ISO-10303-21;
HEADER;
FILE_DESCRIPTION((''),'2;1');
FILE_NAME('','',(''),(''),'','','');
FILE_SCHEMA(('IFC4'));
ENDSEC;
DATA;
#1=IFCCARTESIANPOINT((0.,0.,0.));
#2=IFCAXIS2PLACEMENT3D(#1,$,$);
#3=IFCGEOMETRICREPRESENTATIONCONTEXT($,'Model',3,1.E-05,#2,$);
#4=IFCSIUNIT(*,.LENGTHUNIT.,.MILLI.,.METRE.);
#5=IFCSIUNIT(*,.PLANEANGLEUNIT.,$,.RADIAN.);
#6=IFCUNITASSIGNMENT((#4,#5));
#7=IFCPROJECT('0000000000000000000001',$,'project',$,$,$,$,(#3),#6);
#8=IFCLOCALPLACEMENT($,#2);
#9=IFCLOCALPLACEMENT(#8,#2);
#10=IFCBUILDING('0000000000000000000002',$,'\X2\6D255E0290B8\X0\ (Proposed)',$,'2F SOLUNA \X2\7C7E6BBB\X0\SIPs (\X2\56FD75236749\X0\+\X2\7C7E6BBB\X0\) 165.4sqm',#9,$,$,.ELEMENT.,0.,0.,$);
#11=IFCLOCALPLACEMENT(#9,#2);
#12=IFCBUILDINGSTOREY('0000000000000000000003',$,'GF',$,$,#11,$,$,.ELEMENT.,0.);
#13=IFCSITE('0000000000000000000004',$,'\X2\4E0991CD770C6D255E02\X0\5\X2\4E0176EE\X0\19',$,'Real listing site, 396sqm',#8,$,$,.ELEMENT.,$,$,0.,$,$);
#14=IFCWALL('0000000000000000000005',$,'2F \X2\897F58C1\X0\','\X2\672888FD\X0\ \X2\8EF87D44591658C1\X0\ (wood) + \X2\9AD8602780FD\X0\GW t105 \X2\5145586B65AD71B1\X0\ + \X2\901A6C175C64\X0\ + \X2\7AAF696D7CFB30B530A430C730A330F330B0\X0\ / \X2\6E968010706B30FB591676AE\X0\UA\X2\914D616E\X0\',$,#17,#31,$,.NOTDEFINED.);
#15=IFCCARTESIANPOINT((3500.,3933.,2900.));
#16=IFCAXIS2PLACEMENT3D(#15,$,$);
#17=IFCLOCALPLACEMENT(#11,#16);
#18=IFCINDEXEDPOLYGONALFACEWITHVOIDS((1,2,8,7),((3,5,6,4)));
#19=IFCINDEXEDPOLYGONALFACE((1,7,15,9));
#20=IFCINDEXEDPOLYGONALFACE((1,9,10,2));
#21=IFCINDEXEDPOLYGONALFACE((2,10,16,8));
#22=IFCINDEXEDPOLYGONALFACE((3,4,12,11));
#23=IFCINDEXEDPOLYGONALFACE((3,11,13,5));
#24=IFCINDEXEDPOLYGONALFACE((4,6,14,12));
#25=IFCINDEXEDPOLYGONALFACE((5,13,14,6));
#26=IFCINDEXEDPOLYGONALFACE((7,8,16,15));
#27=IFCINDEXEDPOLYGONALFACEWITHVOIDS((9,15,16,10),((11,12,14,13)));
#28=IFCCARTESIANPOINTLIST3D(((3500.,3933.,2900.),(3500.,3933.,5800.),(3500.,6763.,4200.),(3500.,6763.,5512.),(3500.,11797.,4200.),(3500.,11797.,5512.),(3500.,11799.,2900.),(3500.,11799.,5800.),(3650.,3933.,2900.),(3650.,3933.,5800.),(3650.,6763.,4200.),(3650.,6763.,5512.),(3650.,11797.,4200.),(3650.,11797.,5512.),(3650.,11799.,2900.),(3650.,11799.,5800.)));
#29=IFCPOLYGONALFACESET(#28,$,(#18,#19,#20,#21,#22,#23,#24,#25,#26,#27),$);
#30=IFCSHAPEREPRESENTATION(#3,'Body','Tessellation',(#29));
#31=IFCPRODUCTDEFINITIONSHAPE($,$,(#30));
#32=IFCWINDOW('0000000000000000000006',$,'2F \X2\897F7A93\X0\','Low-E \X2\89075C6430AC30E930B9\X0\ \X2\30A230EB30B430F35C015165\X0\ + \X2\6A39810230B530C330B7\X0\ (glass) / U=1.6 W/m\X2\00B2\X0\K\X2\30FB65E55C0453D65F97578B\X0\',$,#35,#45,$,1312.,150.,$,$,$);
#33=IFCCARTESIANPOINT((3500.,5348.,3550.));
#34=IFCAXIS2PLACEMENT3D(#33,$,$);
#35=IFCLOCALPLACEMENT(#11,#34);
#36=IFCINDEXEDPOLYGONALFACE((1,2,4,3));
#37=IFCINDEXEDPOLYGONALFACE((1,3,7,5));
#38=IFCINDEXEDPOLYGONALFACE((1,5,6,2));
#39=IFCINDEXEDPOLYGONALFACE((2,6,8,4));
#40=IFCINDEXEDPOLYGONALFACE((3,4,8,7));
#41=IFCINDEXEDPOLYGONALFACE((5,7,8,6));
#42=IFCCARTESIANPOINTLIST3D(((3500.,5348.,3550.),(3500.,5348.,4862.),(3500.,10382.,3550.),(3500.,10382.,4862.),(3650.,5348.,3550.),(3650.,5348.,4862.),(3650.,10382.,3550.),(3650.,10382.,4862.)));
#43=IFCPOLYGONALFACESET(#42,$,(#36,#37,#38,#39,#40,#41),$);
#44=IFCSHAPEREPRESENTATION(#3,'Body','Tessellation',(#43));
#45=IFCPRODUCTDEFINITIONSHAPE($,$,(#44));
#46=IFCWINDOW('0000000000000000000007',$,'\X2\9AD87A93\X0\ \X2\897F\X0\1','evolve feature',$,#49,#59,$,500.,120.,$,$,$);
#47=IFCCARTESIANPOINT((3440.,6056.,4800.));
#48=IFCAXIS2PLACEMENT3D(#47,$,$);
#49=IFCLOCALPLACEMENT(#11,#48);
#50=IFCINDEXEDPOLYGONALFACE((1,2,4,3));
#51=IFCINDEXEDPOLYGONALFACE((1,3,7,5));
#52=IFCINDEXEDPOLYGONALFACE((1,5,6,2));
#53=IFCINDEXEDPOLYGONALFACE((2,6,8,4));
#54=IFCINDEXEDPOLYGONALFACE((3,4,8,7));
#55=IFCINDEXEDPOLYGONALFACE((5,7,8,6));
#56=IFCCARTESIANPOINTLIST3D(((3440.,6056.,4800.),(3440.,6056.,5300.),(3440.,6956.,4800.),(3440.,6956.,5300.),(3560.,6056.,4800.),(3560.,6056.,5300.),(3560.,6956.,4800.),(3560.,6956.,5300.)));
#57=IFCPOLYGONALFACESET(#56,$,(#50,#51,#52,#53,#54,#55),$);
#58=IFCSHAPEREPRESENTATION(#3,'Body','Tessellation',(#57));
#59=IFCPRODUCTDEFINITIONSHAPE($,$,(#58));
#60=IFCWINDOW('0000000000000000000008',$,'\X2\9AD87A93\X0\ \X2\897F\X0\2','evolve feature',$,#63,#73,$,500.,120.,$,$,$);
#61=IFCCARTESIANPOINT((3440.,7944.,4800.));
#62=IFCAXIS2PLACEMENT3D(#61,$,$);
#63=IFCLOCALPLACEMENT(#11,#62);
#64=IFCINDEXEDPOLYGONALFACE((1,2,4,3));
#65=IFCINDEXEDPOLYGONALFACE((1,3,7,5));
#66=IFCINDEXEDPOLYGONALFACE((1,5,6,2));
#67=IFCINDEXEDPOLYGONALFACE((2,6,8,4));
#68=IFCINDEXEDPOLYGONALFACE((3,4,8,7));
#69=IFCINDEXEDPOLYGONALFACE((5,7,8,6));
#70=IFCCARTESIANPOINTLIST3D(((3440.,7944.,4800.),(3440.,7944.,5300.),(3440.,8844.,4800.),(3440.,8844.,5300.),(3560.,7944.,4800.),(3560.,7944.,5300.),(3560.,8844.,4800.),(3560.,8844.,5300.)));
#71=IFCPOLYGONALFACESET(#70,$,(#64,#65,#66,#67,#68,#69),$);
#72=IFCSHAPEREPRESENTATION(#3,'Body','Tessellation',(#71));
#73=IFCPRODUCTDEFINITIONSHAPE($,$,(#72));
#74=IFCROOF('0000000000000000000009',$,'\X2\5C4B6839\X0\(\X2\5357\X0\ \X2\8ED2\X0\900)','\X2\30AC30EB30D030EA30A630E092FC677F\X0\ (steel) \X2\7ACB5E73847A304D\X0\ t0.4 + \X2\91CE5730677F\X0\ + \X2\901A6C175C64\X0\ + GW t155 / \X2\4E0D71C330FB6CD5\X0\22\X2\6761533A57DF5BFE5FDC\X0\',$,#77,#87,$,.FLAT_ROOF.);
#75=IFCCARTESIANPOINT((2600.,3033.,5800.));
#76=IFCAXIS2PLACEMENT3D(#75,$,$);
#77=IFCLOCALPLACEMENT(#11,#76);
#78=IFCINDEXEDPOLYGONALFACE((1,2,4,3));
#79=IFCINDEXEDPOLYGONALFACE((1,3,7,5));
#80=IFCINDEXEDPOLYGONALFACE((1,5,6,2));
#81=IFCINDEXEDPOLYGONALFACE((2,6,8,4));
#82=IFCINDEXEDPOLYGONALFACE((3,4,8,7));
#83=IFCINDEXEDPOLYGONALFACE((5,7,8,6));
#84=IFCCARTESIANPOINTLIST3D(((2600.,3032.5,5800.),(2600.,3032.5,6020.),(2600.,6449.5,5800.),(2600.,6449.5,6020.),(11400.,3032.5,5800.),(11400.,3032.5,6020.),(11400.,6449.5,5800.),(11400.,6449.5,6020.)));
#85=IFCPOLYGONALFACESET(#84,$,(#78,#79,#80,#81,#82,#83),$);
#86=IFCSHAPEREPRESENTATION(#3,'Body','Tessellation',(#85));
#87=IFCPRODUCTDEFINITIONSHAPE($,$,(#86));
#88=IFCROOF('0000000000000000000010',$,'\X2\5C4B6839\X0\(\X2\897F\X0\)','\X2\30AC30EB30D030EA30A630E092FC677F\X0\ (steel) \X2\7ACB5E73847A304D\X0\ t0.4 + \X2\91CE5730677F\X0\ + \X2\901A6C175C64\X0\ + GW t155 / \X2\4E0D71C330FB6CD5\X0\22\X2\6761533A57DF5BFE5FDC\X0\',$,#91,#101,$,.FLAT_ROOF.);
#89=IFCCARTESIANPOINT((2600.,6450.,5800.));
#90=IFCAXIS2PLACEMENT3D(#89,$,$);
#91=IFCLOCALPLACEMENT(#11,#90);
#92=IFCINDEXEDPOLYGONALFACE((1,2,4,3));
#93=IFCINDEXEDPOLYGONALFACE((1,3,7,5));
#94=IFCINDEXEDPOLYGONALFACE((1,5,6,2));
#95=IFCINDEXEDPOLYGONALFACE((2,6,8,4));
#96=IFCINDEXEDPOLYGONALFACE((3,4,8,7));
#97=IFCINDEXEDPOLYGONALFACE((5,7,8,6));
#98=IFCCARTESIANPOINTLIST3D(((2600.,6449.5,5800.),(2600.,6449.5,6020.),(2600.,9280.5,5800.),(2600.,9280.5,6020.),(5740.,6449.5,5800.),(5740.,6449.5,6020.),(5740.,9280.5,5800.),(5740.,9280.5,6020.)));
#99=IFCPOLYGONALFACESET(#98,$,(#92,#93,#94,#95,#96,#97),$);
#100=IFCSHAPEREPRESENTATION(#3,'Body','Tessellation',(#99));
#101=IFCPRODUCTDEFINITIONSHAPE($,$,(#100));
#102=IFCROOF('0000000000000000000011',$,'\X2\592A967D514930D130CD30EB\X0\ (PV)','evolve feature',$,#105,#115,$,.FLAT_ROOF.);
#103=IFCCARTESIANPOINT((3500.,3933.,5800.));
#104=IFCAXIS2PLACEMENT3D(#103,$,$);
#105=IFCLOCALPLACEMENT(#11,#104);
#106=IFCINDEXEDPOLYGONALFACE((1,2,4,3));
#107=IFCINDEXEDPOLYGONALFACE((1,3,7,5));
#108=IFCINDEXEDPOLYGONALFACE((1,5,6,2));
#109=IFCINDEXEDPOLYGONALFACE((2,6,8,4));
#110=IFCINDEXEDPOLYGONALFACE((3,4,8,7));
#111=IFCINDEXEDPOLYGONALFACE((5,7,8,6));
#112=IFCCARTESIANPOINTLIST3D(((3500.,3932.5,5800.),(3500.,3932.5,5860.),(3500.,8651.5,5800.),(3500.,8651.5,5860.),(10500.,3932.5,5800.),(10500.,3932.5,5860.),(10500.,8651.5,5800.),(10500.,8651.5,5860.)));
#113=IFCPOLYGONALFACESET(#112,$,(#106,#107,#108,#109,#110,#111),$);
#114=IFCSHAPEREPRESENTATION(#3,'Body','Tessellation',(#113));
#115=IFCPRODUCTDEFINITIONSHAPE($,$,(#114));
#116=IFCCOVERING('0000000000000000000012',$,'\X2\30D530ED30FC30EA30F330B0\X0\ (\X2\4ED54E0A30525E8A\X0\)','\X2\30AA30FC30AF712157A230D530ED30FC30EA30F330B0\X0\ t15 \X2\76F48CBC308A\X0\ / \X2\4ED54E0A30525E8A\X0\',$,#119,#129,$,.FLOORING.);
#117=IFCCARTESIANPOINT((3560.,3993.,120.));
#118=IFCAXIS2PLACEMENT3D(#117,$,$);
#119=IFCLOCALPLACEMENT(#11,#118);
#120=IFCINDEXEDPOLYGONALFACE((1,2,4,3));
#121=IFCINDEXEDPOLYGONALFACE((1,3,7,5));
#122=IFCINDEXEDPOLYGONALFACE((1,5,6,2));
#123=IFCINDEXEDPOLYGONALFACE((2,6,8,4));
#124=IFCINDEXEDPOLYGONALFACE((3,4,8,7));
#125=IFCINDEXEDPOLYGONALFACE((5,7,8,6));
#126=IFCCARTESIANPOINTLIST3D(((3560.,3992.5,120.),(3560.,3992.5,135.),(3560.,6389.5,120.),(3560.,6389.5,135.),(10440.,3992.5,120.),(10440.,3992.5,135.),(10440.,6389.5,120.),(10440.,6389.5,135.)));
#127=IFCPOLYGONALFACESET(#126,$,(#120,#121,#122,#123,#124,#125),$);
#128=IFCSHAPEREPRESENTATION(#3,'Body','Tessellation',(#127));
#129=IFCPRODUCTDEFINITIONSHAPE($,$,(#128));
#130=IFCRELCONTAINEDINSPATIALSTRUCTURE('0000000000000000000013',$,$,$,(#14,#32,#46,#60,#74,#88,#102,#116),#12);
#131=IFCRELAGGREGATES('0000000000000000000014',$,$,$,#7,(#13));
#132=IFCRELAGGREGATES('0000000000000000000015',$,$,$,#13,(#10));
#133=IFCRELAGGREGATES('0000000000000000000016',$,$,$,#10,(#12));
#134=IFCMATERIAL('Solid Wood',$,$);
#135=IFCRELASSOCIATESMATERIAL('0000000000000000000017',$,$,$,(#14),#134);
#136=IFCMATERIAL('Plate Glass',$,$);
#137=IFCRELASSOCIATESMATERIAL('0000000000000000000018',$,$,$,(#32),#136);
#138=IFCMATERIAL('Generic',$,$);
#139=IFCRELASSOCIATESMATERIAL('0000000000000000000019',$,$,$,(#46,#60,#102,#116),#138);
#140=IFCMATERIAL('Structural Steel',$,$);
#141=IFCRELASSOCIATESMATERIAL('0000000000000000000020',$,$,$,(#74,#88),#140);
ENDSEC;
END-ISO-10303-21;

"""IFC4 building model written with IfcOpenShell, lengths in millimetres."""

from ifc_helpers import new_model, si_unit, frame, frame_2d, origin, place, context, project, spatial, rectangle, extrude, material, element, fill, save


model = new_model("IFC4")

# Units and contexts
model_context = context("Model", 3, precision=1e-05, world=origin())
ifc_project = project(units=[si_unit("LENGTHUNIT", "METRE", prefix="MILLI"), si_unit("PLANEANGLEUNIT", "RADIAN")], contexts=[model_context])

# Site, building, storey
site_placement = place(None, origin())
site = spatial("IfcSite", under=ifc_project, at=site_placement, Name="三重県津市5丁目19", ObjectType="Real listing site, 396sqm", CompositionType="ELEMENT", RefElevation=0.0)
building_placement = place(site_placement, origin())
building = spatial("IfcBuilding", under=site, at=building_placement, Name="津市邸 (Proposed)", ObjectType="2F SOLUNA 籾殻SIPs (国産杉+籾殻) 165.4sqm", CompositionType="ELEMENT", ElevationOfRefHeight=0.0, ElevationOfTerrain=0.0)
storey_placement = place(building_placement, origin())
storey = spatial("IfcBuildingStorey", under=building, at=storey_placement, Name="GF", CompositionType="ELEMENT", Elevation=0.0)

# Shared definitions
ifc_material_1 = material(Name="Solid Wood")
ifc_material_2 = material(Name="Generic")

# Shared definitions
ifc_material_3 = material(Name="Plate Glass")

# Wall, openings, windows
wall_1_placement = place(storey_placement, frame((3500.0, 3933.0, 2900.0)))
wall_1 = element("IfcWall", 1, at=wall_1_placement, inside=storey, material=ifc_material_1, Name="2F 西壁", Description="木製 軸組外壁 (wood) + 高性能GW t105 充填断熱 + 通気層 + 窯業系サイディング / 準耐火・外皮UA配慮", PredefinedType="NOTDEFINED", context=model_context, shape_type="SweptSolid", body=[
    extrude(rectangle(XDim=150.0, YDim=7866.0, at=frame_2d((75.0, 3933.0))), frame((3500.0, 3933.0, 2900.0)), (0.0, 0.0, 1.0), 2900.0),
])
opening_1_placement = place(storey_placement, frame((3500.0, 5348.0, 3550.0)))
opening_1 = element("IfcOpeningElement", 2, at=opening_1_placement, cuts=wall_1, PredefinedType="NOTDEFINED", context=model_context, shape_type="SweptSolid", body=[
    extrude(rectangle(XDim=150.0, YDim=5034.0, at=frame_2d((75.0, 2517.0))), frame((3500.0, 5348.0, 3550.0)), (0.0, 0.0, 1.0), 1312.0),
])
opening_2_placement = place(storey_placement, frame((3440.0, 6056.0, 4800.0)))
opening_2 = element("IfcOpeningElement", 3, at=opening_2_placement, cuts=wall_1, PredefinedType="NOTDEFINED", context=model_context, shape_type="SweptSolid", body=[
    extrude(rectangle(XDim=120.0, YDim=900.0, at=frame_2d((60.0, 450.0))), frame((3440.0, 6056.0, 4800.0)), (0.0, 0.0, 1.0), 500.0),
])
opening_3_placement = place(storey_placement, frame((3440.0, 7944.0, 4800.0)))
opening_3 = element("IfcOpeningElement", 4, at=opening_3_placement, cuts=wall_1, PredefinedType="NOTDEFINED", context=model_context, shape_type="SweptSolid", body=[
    extrude(rectangle(XDim=120.0, YDim=900.0, at=frame_2d((60.0, 450.0))), frame((3440.0, 7944.0, 4800.0)), (0.0, 0.0, 1.0), 500.0),
])
window_1_placement = place(storey_placement, frame((3500.0, 5348.0, 3550.0)))
window_1 = element("IfcWindow", 5, at=window_1_placement, inside=storey, material=ifc_material_3, Name="2F 西窓", Description="Low-E 複層ガラス アルゴン封入 + 樹脂サッシ (glass) / U=1.6 W/m²K・日射取得型", OverallHeight=1312.0, OverallWidth=150.0, context=model_context, shape_type="SweptSolid", body=[
    extrude(rectangle(XDim=150.0, YDim=5034.0, at=frame_2d((75.0, 2517.0))), frame((3500.0, 5348.0, 3550.0)), (0.0, 0.0, 1.0), 1312.0),
])
fill(opening_1, window_1)
window_2_placement = place(storey_placement, frame((3440.0, 6056.0, 4800.0)))
window_2 = element("IfcWindow", 6, at=window_2_placement, inside=storey, material=ifc_material_2, Name="高窓 西1", Description="evolve feature", OverallHeight=500.0, OverallWidth=120.0, context=model_context, shape_type="SweptSolid", body=[
    extrude(rectangle(XDim=120.0, YDim=900.0, at=frame_2d((60.0, 450.0))), frame((3440.0, 6056.0, 4800.0)), (0.0, 0.0, 1.0), 500.0),
])
fill(opening_2, window_2)
window_3_placement = place(storey_placement, frame((3440.0, 7944.0, 4800.0)))
window_3 = element("IfcWindow", 7, at=window_3_placement, inside=storey, material=ifc_material_2, Name="高窓 西2", Description="evolve feature", OverallHeight=500.0, OverallWidth=120.0, context=model_context, shape_type="SweptSolid", body=[
    extrude(rectangle(XDim=120.0, YDim=900.0, at=frame_2d((60.0, 450.0))), frame((3440.0, 7944.0, 4800.0)), (0.0, 0.0, 1.0), 500.0),
])
fill(opening_3, window_3)

# Roofs
ifc_material_4 = material(Name="Structural Steel")
roof_1_placement = place(storey_placement, frame((2600.0, 3033.0, 5800.0)))
element("IfcRoof", 8, at=roof_1_placement, inside=storey, material=ifc_material_4, Name="屋根(南 軒900)", Description="ガルバリウム鋼板 (steel) 立平葺き t0.4 + 野地板 + 通気層 + GW t155 / 不燃・法22条区域対応", PredefinedType="FLAT_ROOF", context=model_context, shape_type="SweptSolid", body=[
    extrude(rectangle(XDim=8800.0, YDim=3417.0, at=frame_2d((4400.0, 1708.0))), frame((2600.0, 3033.0, 5800.0)), (0.0, 0.0, 1.0), 220.0),
])
roof_2_placement = place(storey_placement, frame((2600.0, 6450.0, 5800.0)))
element("IfcRoof", 9, at=roof_2_placement, inside=storey, material=ifc_material_4, Name="屋根(西)", Description="ガルバリウム鋼板 (steel) 立平葺き t0.4 + 野地板 + 通気層 + GW t155 / 不燃・法22条区域対応", PredefinedType="FLAT_ROOF", context=model_context, shape_type="SweptSolid", body=[
    extrude(rectangle(XDim=3140.0, YDim=2831.0, at=frame_2d((1570.0, 1415.0))), frame((2600.0, 6450.0, 5800.0)), (0.0, 0.0, 1.0), 220.0),
])
roof_3_placement = place(storey_placement, frame((3500.0, 3933.0, 5800.0)))
element("IfcRoof", 10, at=roof_3_placement, inside=storey, material=ifc_material_2, Name="太陽光パネル (PV)", Description="evolve feature", PredefinedType="FLAT_ROOF", context=model_context, shape_type="SweptSolid", body=[
    extrude(rectangle(XDim=7000.0, YDim=4719.0, at=frame_2d((3500.0, 2359.0))), frame((3500.0, 3933.0, 5800.0)), (0.0, 0.0, 1.0), 60.0),
])

# Covering
covering_placement = place(storey_placement, frame((3560.0, 3993.0, 120.0)))
element("IfcCovering", 11, at=covering_placement, inside=storey, material=ifc_material_2, Name="フローリング (仕上げ床)", Description="オーク無垢フローリング t15 直貼り / 仕上げ床", PredefinedType="FLOORING", context=model_context, shape_type="SweptSolid", body=[
    extrude(rectangle(XDim=6880.0, YDim=2397.0, at=frame_2d((3440.0, 1198.0))), frame((3560.0, 3993.0, 120.0)), (0.0, 0.0, 1.0), 15.0),
])

save(model, "model.ifc")
